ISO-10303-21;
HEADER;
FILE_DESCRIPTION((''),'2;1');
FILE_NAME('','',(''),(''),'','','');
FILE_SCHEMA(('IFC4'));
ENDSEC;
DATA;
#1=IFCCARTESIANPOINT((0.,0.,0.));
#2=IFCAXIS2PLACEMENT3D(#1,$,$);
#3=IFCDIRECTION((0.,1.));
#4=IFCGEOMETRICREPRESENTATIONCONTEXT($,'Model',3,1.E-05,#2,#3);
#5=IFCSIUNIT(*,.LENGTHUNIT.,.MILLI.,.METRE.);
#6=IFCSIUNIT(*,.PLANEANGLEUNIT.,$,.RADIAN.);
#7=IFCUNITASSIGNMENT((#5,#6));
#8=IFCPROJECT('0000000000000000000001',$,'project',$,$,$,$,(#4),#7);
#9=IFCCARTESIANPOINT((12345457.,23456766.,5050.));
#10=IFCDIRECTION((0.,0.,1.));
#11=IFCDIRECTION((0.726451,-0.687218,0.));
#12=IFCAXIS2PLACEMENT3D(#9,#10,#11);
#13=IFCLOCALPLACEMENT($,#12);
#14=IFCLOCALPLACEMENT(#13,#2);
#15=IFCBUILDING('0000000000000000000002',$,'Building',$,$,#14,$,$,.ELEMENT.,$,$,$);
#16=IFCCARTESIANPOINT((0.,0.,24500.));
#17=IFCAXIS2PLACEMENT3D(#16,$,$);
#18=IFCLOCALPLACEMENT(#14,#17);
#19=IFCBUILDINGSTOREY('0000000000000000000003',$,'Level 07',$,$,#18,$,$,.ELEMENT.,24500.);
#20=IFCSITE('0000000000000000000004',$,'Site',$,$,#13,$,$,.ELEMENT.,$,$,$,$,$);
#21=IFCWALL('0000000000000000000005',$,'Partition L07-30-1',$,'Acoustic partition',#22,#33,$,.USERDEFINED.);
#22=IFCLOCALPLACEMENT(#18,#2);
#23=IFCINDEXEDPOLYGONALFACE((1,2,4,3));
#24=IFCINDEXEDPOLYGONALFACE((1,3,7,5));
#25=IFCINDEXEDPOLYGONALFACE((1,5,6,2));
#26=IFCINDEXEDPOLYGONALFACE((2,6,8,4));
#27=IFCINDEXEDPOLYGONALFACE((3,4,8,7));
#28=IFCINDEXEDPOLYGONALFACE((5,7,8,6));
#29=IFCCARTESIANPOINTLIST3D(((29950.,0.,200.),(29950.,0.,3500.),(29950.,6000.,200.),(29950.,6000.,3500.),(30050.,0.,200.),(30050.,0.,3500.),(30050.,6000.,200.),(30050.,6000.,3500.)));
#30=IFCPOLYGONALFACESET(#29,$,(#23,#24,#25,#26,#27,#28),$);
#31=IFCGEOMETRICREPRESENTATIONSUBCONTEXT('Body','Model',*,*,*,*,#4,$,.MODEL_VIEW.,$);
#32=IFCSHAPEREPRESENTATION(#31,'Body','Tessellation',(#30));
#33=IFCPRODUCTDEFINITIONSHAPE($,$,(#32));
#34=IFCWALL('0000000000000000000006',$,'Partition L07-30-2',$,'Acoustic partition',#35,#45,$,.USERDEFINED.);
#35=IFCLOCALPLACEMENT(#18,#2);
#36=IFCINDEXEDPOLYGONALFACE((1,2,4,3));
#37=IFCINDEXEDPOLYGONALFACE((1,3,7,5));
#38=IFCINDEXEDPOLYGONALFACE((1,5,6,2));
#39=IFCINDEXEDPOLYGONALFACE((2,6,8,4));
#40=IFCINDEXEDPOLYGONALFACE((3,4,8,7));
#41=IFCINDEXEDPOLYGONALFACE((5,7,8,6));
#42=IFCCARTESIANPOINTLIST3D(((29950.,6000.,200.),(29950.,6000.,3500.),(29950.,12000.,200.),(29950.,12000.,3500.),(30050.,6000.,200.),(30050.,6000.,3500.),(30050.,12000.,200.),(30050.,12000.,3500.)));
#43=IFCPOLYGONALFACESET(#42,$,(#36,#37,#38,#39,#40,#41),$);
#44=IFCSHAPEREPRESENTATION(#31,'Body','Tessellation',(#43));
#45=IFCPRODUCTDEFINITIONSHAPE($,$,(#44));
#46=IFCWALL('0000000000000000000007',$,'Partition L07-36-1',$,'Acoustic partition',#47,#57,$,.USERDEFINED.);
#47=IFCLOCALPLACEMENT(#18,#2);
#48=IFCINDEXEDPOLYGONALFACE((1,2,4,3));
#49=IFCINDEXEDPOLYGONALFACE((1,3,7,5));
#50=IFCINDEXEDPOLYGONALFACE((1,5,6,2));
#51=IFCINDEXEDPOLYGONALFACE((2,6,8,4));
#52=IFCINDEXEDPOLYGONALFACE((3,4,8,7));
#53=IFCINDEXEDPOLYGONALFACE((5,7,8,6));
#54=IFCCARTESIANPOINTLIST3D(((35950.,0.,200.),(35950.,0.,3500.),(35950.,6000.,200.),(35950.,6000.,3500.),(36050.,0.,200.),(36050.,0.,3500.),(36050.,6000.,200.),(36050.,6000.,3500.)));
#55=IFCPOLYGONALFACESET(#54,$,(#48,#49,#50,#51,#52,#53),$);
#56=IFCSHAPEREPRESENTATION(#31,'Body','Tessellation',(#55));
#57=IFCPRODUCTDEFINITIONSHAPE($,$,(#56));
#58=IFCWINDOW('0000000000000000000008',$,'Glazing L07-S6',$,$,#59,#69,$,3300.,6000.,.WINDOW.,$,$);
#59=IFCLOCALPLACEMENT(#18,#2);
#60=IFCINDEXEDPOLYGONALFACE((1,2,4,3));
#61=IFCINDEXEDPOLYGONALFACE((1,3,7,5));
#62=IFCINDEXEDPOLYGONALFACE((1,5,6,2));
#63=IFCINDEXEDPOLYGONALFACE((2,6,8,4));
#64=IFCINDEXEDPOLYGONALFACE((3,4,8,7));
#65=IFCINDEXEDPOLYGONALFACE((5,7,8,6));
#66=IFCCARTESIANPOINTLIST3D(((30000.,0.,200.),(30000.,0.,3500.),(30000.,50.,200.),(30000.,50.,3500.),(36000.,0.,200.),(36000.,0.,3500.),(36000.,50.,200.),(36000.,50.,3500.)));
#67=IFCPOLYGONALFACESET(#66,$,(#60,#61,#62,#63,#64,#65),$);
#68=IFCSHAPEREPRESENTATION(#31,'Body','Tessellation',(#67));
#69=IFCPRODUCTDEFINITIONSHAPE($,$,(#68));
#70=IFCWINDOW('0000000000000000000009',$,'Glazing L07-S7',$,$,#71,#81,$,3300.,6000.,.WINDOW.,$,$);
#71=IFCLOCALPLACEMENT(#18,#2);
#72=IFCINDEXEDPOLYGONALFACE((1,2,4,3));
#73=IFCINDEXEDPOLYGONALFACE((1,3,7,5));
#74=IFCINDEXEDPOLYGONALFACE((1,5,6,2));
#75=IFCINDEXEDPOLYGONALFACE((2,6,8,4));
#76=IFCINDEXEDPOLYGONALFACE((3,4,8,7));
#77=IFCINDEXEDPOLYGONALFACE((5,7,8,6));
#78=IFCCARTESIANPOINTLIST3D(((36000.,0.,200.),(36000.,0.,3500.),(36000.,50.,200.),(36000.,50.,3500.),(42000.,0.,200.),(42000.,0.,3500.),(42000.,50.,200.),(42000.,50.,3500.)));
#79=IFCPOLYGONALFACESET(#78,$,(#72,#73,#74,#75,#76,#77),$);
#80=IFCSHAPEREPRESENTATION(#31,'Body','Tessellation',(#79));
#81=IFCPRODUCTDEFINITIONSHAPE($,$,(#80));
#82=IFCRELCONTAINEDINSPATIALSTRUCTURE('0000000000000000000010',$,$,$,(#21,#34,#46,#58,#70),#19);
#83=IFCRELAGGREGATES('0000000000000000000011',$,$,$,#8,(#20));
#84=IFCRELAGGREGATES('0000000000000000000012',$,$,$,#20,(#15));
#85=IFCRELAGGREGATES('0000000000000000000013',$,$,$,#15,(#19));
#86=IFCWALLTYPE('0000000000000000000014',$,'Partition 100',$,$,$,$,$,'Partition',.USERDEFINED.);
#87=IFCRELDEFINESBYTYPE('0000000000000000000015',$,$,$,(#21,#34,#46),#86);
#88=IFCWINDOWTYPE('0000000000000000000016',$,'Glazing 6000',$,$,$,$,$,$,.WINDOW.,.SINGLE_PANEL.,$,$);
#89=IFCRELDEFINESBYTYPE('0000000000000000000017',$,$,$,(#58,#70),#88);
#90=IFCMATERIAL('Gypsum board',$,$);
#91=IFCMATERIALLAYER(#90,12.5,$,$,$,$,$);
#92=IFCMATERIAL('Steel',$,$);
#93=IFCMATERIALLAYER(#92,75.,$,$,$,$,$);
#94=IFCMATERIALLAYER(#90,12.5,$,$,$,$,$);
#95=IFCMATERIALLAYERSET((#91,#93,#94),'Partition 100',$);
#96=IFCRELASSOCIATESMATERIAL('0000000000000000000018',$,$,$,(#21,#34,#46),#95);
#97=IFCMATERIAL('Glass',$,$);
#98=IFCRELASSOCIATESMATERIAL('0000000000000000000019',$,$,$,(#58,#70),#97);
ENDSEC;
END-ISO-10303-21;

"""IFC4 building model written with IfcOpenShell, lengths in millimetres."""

from ifc_helpers import new_model, si_unit, direction, frame, origin, place, context, subcontext, project, spatial, rectangle, extrude, material, layer, layer_set, layer_usage, type_object, element, save


model = new_model("IFC4")

# Units and contexts
model_context = context("Model", 3, precision=1e-05, world=origin(), true_north=direction((0.0, 1.0)))
body_context = subcontext(model_context, "Body", "Model", "MODEL_VIEW")
ifc_project = project(units=[si_unit("LENGTHUNIT", "METRE", prefix="MILLI"), si_unit("PLANEANGLEUNIT", "RADIAN")], contexts=[model_context])

# Site, building, storey
site_placement = place(None, frame((12345457.0, 23456766.0, 5050.0), z_axis=(0.0, 0.0, 1.0), x_axis=(0.726451, -0.687218, 0.0)))
site = spatial("IfcSite", under=ifc_project, at=site_placement, Name="Site", CompositionType="ELEMENT")
building_placement = place(site_placement, origin())
building = spatial("IfcBuilding", under=site, at=building_placement, Name="Building", CompositionType="ELEMENT")
storey_placement = place(building_placement, frame((0.0, 0.0, 24500.0)))
storey = spatial("IfcBuildingStorey", under=building, at=storey_placement, Name="Level 07", CompositionType="ELEMENT", Elevation=24500.0)

# Shared definitions
ifc_material_1 = material(Name="Steel")

# Walls
ifc_material_2 = material(Name="Gypsum board")
ifc_layer_1 = layer(ifc_material_2, 12.5)
ifc_layer_2 = layer(ifc_material_1, 75.0)
ifc_layer_3 = layer(ifc_material_2, 12.5)
ifc_layer_set = layer_set([ifc_layer_1, ifc_layer_2, ifc_layer_3], Name="Partition 100")
ifc_layer_usage = layer_usage(ifc_layer_set, "AXIS2", "POSITIVE", 0.0)
wall_type = type_object("IfcWallType", Name="Partition 100", ElementType="Partition", PredefinedType="USERDEFINED")
for number, where, name in (
    (1, (29950.0, 0.0, 200.0), "Partition L07-30-1"),
    (2, (29950.0, 6000.0, 200.0), "Partition L07-30-2"),
    (3, (35950.0, 0.0, 200.0), "Partition L07-36-1"),
):
    element("IfcWall", number, at=place(storey_placement, frame(where)), inside=storey, type_object=wall_type, material=ifc_layer_usage, Name=name, ObjectType="Acoustic partition", PredefinedType="USERDEFINED", context=body_context, shape_type="SweptSolid", body=[
        extrude(rectangle(XDim=100.0, YDim=6000.0), frame((50.0, 3000.0, 0.0)), (0.0, 0.0, 1.0), 3300.0),
    ])

# Windows
ifc_material_3 = material(Name="Glass")
window_type = type_object("IfcWindowType", Name="Glazing 6000", PartitioningType="SINGLE_PANEL", PredefinedType="WINDOW")
for number, where, name in (
    (4, (30000.0, 0.0, 200.0), "Glazing L07-S6"),
    (5, (36000.0, 0.0, 200.0), "Glazing L07-S7"),
):
    element("IfcWindow", number, at=place(storey_placement, frame(where)), inside=storey, type_object=window_type, material=ifc_material_3, Name=name, OverallHeight=3300.0, OverallWidth=6000.0, PredefinedType="WINDOW", context=body_context, shape_type="SweptSolid", body=[
        extrude(rectangle(XDim=6000.0, YDim=50.0), frame((3000.0, 25.0, 0.0)), (0.0, 0.0, 1.0), 3300.0),
    ])

save(model, "model.ifc")
